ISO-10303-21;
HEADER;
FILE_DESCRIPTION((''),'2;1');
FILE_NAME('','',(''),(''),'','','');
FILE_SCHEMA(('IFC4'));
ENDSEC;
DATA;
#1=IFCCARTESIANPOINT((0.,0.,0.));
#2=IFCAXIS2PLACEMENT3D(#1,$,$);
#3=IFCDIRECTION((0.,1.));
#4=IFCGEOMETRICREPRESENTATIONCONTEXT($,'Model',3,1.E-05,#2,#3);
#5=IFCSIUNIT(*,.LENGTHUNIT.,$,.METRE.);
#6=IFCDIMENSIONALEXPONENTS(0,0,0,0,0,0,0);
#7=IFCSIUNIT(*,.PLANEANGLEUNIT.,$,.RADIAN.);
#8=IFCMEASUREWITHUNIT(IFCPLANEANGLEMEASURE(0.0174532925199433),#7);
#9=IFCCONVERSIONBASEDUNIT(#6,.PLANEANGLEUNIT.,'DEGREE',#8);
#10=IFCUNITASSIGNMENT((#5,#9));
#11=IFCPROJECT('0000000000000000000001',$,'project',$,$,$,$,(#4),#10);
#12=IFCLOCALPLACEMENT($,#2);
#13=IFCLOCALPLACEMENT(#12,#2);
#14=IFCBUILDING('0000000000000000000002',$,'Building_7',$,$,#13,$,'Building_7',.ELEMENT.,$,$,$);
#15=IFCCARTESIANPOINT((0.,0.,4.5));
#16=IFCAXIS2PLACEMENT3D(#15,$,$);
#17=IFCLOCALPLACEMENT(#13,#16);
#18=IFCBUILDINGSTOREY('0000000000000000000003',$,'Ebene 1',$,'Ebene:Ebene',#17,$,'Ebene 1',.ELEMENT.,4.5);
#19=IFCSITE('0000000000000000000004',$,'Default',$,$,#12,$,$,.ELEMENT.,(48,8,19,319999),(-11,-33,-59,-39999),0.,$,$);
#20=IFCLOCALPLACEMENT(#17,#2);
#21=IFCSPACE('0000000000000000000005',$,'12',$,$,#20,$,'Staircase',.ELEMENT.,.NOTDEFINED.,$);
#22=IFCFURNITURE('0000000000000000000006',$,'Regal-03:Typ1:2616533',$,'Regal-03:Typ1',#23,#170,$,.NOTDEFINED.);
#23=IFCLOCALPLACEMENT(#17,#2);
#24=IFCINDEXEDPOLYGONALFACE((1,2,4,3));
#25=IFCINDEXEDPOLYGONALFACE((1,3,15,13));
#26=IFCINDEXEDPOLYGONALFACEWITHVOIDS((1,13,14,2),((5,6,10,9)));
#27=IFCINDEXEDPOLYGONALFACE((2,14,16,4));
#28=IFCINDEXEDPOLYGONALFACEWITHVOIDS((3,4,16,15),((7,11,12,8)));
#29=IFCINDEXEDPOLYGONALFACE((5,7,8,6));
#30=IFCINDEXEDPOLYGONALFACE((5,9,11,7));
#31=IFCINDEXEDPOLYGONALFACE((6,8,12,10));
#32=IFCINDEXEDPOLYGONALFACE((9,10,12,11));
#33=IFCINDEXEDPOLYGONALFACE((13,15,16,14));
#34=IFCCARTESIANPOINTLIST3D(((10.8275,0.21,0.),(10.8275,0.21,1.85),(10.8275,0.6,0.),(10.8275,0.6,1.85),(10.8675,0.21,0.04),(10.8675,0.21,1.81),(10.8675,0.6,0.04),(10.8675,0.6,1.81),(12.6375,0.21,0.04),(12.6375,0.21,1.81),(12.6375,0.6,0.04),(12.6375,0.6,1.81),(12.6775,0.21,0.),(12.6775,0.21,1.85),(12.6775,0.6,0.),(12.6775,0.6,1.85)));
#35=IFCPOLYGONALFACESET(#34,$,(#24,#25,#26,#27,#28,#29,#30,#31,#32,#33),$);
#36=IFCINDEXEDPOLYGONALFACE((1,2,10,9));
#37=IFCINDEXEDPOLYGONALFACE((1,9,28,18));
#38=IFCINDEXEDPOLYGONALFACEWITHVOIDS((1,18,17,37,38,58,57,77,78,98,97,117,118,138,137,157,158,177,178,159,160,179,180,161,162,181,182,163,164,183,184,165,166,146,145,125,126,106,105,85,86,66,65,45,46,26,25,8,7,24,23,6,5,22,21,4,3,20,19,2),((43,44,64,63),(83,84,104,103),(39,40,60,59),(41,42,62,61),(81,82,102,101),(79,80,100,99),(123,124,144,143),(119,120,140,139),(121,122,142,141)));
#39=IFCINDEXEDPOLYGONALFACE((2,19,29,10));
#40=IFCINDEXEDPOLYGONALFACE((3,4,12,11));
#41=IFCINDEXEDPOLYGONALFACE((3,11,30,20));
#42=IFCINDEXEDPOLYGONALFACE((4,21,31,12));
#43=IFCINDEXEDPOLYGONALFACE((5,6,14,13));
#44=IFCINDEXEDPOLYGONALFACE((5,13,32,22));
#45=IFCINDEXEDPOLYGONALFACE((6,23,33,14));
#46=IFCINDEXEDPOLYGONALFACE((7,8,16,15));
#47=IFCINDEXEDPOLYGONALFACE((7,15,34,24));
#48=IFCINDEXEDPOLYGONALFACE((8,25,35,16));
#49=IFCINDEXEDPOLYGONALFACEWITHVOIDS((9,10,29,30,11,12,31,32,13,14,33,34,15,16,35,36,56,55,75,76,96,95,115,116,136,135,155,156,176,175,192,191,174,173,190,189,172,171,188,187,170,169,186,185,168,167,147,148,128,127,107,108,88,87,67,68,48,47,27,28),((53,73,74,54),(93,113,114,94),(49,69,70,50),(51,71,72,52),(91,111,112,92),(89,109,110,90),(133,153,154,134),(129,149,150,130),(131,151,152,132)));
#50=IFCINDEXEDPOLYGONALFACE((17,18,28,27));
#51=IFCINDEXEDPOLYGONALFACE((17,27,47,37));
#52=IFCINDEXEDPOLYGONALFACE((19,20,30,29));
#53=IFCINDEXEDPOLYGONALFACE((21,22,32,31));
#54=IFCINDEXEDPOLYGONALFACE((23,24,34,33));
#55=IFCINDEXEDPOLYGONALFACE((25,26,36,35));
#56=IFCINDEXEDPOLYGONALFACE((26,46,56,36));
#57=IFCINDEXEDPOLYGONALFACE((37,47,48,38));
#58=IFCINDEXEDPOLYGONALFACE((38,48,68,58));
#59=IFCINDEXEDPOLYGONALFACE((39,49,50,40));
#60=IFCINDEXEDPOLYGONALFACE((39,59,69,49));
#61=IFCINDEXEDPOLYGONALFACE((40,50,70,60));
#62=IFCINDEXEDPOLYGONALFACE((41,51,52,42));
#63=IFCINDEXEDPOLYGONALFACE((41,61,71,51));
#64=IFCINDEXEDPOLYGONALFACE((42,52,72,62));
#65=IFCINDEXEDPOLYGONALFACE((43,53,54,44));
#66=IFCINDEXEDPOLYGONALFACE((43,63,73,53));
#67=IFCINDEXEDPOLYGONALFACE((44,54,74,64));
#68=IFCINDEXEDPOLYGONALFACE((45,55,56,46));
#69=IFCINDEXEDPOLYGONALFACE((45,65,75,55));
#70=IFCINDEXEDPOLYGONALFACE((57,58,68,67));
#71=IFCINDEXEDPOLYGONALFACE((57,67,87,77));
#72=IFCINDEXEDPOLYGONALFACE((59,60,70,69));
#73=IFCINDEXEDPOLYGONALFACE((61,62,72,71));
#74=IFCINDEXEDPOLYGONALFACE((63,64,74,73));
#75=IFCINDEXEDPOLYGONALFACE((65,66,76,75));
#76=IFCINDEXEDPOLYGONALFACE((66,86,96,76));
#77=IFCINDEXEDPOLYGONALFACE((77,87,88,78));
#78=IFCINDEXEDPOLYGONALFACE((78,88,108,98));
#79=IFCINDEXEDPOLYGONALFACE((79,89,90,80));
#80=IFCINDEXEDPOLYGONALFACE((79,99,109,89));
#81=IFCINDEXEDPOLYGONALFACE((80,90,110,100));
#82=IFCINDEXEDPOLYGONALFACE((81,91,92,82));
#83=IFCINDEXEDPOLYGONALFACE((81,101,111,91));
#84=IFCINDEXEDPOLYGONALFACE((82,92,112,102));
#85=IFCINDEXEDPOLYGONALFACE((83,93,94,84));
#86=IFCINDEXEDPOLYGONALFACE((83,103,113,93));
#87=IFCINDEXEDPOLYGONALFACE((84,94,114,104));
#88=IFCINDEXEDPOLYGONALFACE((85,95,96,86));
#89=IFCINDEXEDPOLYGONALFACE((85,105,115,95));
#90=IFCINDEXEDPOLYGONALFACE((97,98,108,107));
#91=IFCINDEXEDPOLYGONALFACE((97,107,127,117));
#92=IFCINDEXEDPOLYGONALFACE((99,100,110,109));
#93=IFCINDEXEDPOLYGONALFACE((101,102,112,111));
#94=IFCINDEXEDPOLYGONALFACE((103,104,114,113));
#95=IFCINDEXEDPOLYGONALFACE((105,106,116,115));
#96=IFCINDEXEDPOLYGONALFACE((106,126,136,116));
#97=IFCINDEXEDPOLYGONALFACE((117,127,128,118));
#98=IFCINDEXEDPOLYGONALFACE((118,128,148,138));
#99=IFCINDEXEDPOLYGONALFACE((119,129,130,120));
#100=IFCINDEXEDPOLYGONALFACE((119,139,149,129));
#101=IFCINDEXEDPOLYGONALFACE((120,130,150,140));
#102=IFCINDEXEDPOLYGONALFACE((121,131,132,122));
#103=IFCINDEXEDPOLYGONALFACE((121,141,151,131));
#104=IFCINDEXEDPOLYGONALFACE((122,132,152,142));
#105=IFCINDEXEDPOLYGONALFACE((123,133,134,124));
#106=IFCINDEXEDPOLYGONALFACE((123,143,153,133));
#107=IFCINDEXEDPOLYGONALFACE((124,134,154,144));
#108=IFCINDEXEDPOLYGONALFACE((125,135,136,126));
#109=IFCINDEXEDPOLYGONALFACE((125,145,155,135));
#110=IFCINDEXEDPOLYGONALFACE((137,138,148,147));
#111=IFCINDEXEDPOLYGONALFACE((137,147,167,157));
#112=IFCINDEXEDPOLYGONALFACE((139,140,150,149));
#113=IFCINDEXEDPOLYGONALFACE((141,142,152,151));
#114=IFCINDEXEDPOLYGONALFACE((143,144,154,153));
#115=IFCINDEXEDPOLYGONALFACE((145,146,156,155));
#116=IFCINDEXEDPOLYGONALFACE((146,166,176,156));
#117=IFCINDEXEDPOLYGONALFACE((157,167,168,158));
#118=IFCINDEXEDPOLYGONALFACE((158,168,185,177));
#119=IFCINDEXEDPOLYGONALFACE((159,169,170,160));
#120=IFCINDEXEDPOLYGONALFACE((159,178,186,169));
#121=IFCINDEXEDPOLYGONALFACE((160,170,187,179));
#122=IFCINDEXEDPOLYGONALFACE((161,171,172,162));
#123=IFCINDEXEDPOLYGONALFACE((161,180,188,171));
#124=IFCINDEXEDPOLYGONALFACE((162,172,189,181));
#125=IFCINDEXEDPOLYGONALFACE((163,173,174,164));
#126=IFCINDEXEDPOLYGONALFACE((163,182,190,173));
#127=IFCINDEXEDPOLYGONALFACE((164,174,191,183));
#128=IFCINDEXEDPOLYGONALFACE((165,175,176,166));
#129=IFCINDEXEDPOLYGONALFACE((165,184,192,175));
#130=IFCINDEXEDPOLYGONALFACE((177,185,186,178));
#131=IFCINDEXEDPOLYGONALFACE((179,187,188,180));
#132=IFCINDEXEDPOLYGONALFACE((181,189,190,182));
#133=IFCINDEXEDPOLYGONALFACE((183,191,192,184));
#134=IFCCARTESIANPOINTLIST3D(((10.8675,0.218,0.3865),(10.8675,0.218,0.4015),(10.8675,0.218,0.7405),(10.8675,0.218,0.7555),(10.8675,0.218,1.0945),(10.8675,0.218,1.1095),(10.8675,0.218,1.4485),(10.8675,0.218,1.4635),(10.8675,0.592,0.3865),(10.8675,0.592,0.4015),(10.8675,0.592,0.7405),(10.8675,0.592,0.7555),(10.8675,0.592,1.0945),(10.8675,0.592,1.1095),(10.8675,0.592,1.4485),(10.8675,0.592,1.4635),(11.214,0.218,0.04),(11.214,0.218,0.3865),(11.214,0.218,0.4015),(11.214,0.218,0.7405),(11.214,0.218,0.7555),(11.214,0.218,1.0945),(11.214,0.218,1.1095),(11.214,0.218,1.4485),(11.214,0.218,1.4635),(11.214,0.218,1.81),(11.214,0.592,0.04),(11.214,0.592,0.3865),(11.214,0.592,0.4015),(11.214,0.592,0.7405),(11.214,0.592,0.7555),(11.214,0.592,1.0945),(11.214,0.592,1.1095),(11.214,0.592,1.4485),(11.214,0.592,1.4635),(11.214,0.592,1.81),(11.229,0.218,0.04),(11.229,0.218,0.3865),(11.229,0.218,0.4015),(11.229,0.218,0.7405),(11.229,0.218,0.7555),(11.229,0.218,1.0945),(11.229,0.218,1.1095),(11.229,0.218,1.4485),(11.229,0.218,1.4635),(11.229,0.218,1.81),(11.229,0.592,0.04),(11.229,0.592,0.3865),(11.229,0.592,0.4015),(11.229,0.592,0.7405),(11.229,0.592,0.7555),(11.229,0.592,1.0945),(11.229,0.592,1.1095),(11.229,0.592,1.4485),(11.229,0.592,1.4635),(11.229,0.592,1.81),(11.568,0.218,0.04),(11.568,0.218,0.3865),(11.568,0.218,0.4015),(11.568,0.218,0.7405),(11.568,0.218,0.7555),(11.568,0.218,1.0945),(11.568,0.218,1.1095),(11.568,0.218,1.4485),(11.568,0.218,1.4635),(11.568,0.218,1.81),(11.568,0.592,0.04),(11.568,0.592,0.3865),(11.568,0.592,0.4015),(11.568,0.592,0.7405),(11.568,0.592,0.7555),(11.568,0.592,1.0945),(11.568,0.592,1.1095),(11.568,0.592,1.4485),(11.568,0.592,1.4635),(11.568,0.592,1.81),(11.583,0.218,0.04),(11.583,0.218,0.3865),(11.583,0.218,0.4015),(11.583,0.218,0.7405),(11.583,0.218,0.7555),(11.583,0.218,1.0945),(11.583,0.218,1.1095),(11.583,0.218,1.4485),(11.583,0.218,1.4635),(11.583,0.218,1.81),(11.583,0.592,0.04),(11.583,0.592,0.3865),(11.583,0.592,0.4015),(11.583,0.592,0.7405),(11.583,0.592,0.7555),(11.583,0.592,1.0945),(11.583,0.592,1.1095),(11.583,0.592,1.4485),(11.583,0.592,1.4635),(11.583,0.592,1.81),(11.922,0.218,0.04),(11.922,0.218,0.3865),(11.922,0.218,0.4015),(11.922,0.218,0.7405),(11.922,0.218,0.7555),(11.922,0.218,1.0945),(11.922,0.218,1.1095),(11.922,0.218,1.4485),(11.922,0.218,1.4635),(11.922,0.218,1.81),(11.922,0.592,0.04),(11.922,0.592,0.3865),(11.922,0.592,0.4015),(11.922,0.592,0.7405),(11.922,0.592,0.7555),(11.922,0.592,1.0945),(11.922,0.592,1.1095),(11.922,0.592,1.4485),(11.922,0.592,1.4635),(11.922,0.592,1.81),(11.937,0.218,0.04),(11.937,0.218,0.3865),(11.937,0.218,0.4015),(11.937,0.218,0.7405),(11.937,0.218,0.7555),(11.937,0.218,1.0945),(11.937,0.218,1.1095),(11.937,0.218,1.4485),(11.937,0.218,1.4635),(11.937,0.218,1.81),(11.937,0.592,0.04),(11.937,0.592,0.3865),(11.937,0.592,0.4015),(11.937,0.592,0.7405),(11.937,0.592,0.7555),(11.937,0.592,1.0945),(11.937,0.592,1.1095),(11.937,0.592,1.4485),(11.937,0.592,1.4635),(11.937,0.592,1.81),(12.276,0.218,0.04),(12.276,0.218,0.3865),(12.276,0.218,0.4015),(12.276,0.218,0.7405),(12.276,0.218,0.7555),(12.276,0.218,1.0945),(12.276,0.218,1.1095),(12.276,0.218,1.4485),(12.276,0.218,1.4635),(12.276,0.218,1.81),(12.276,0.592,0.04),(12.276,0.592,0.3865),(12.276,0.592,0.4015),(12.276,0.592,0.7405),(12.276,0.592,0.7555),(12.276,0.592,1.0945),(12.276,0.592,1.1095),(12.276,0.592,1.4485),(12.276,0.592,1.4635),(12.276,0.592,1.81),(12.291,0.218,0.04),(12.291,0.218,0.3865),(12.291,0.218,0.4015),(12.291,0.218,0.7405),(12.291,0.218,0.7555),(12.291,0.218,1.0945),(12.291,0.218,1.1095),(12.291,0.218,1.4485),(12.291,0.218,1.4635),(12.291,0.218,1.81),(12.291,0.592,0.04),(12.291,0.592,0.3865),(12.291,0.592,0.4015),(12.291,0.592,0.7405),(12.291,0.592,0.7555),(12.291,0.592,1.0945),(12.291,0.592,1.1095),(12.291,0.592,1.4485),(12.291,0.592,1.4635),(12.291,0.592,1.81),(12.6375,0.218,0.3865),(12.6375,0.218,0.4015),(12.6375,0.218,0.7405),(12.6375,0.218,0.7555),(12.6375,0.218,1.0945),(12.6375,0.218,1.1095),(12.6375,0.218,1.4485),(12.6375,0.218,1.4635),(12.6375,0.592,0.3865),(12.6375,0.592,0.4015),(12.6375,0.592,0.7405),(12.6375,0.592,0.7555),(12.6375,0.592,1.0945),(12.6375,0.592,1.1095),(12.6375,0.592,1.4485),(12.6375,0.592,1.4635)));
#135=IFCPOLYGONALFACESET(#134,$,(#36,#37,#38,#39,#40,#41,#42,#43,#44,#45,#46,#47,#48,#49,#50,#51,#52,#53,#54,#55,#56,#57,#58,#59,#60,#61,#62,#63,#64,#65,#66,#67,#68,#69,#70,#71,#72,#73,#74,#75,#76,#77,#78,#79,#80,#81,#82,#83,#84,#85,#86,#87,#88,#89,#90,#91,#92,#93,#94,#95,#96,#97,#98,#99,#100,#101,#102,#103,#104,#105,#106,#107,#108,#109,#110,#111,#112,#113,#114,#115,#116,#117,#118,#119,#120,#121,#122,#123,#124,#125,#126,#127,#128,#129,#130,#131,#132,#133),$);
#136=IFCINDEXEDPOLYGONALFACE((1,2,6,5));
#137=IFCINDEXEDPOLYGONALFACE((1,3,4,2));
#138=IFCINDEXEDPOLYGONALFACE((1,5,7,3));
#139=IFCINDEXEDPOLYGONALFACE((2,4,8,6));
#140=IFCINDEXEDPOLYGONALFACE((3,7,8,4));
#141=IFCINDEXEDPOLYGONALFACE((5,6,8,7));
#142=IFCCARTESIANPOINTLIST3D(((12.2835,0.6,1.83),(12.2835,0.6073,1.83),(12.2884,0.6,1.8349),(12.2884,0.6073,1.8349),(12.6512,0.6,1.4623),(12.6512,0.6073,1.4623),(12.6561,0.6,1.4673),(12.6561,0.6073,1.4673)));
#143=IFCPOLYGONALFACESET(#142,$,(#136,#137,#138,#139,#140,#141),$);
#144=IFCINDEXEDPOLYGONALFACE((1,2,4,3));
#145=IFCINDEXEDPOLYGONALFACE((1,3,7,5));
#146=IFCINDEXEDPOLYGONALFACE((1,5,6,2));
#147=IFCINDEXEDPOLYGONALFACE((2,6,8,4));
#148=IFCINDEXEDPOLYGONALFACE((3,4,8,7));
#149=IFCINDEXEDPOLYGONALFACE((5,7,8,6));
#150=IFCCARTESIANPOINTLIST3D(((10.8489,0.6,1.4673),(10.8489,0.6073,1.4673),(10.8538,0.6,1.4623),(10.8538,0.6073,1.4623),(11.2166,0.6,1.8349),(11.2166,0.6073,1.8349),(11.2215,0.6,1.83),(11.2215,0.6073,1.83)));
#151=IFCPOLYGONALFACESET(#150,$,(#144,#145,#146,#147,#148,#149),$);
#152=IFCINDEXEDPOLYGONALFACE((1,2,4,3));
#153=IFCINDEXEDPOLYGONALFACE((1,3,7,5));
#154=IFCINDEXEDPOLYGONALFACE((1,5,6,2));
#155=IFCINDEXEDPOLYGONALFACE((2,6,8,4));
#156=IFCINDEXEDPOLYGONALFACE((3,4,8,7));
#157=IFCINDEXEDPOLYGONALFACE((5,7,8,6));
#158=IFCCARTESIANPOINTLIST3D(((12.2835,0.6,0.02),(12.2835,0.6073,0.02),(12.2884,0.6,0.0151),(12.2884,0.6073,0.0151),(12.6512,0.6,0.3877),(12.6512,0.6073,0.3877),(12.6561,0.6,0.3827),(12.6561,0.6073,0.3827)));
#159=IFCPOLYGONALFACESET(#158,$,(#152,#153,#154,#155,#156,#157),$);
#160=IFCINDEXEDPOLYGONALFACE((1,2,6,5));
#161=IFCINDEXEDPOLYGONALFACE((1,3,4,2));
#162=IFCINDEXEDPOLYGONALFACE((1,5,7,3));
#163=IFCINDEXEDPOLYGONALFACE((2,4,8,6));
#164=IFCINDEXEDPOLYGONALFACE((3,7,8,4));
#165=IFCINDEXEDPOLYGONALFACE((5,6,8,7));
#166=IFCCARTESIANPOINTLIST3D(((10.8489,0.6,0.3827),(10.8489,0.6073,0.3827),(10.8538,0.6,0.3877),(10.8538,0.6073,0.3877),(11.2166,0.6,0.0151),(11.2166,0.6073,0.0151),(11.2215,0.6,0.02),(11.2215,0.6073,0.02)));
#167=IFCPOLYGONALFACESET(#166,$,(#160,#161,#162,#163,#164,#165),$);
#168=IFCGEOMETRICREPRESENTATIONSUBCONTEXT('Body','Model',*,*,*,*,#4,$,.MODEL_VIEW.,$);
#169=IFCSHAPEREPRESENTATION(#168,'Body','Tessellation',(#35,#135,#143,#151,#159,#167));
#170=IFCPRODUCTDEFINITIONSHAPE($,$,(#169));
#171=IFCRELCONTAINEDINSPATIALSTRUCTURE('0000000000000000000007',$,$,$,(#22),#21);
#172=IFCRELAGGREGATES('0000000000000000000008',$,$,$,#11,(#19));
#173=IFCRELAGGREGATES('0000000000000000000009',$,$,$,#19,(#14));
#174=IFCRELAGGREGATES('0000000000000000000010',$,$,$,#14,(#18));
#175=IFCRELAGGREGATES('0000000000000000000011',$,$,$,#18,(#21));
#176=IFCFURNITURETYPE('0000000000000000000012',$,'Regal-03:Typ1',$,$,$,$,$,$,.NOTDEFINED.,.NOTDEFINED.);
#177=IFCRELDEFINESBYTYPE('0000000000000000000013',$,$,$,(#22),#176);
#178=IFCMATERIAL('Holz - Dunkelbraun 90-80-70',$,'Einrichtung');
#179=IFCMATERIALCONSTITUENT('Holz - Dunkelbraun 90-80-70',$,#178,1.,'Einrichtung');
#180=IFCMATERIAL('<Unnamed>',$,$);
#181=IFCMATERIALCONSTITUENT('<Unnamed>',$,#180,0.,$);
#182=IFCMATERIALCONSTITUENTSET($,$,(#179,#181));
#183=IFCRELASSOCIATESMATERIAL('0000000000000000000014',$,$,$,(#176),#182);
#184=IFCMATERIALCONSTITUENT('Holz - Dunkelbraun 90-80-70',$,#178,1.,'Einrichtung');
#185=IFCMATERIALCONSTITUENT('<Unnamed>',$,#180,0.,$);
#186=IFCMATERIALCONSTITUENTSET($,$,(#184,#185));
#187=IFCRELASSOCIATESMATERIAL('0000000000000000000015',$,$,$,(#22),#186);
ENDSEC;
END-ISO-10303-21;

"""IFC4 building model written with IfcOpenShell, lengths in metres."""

from ifc_helpers import new_model, entity, si_unit, converted_unit, direction, frame, origin, place, context, subcontext, project, spatial, indexed_curve, outline, extrude, source, transform, mapped, material, constituent, constituent_set, type_object, type_shapes, element, save


model = new_model("IFC4")

# Units and contexts
model_context = context("Model", 3, precision=1e-05, world=origin(), true_north=direction((0.0, 1.0)))
body_context = subcontext(model_context, "Body", "Model", "MODEL_VIEW")
ifc_project = project(units=[si_unit("LENGTHUNIT", "METRE"), converted_unit("PLANEANGLEUNIT", "DEGREE", entity("IfcPlaneAngleMeasure", 0.0174532925199433), si_unit("PLANEANGLEUNIT", "RADIAN"), dimensions=[0, 0, 0, 0, 0, 0, 0])], contexts=[model_context])

# Site, building, storey
site_placement = place(None, origin())
site = spatial("IfcSite", under=ifc_project, at=site_placement, Name="Default", CompositionType="ELEMENT", RefLatitude=(48, 8, 19, 319999), RefLongitude=(-11, -33, -59, -39999), RefElevation=0.0)
building_placement = place(site_placement, origin())
building = spatial("IfcBuilding", under=site, at=building_placement, Name="Building_7", LongName="Building_7", CompositionType="ELEMENT")
storey_placement = place(building_placement, frame((0.0, 0.0, 4.5)))
storey = spatial("IfcBuildingStorey", under=building, at=storey_placement, Name="Ebene 1", ObjectType="Ebene:Ebene", LongName="Ebene 1", CompositionType="ELEMENT", Elevation=4.5)

# Shared definitions
ifc_material_1 = material(Name="<Unnamed>")

# Shared definitions
ifc_material_2 = material(Name="Holz - Dunkelbraun 90-80-70", Category="Einrichtung")
ifc_constituent_1 = constituent(ifc_material_2, Name="Holz - Dunkelbraun 90-80-70", Category="Einrichtung", fraction=1.0)
ifc_constituent_2 = constituent(ifc_material_1, Name="<Unnamed>", fraction=0.0)
ifc_constituent_set_1 = constituent_set(constituents=[ifc_constituent_1, ifc_constituent_2])
furniture_type_1 = type_object("IfcFurnitureType", Name="Regal-03:Typ1", AssemblyPlace="NOTDEFINED", PredefinedType="NOTDEFINED", material=ifc_constituent_set_1)
shared_shape_1 = source(origin(), body_context, "Body", "SweptSolid", [
    extrude(outline(indexed_curve([(-0.925, -0.925), (0.925, -0.925), (0.925, 0.925), (-0.925, 0.925), (-0.925, -0.925)], self_intersect=False), holes=[indexed_curve([(-0.885, -0.885), (-0.885, 0.885), (0.885, 0.885), (0.885, -0.885), (-0.885, -0.885)], self_intersect=False)]), frame((0.2471, -0.2651, 0.925), z_axis=(0.0, 1.0, 0.0), x_axis=(0.0, 0.0, -1.0)), (0.0, 0.0, 1.0), 0.39),
    extrude(outline(indexed_curve([(0.5385, -0.5385), (0.885, -0.5385), (0.885, -0.5235), (0.5385, -0.5235), (0.5385, -0.1845), (0.885, -0.1845), (0.885, -0.1695), (0.5385, -0.1695), (0.5385, 0.1695), (0.885, 0.1695), (0.885, 0.1845), (0.5385, 0.1845), (0.5385, 0.5235), (0.885, 0.5235), (0.885, 0.5385), (0.5385, 0.5385), (0.5385, 0.885), (0.5235, 0.885), (0.5235, 0.5385), (0.1845, 0.5385), (0.1845, 0.885), (0.1695, 0.885), (0.1695, 0.5385), (-0.1695, 0.5385), (-0.1695, 0.885), (-0.1845, 0.885), (-0.1845, 0.5385), (-0.5235, 0.5385), (-0.5235, 0.885), (-0.5385, 0.885), (-0.5385, 0.5385), (-0.885, 0.5385), (-0.885, 0.5235), (-0.5385, 0.5235), (-0.5385, 0.1845), (-0.885, 0.1845), (-0.885, 0.1695), (-0.5385, 0.1695), (-0.5385, -0.1695), (-0.885, -0.1695), (-0.885, -0.1845), (-0.5385, -0.1845), (-0.5385, -0.5235), (-0.885, -0.5235), (-0.885, -0.5385), (-0.5385, -0.5385), (-0.5385, -0.885), (-0.5235, -0.885), (-0.5235, -0.5385), (-0.1845, -0.5385), (-0.1845, -0.885), (-0.1695, -0.885), (-0.1695, -0.5385), (0.1695, -0.5385), (0.1695, -0.885), (0.1845, -0.885), (0.1845, -0.5385), (0.5235, -0.5385), (0.5235, -0.885), (0.5385, -0.885), (0.5385, -0.5385)], self_intersect=False), holes=[indexed_curve([(0.5235, -0.1845), (0.5235, -0.5235), (0.1845, -0.5235), (0.1845, -0.1845), (0.5235, -0.1845)], self_intersect=False), indexed_curve([(0.1845, -0.1695), (0.1845, 0.1695), (0.5235, 0.1695), (0.5235, -0.1695), (0.1845, -0.1695)], self_intersect=False), indexed_curve([(0.1845, 0.1845), (0.1845, 0.5235), (0.5235, 0.5235), (0.5235, 0.1845), (0.1845, 0.1845)], self_intersect=False), indexed_curve([(-0.1695, 0.5235), (0.1695, 0.5235), (0.1695, 0.1845), (-0.1695, 0.1845), (-0.1695, 0.5235)], self_intersect=False), indexed_curve([(-0.1695, 0.1695), (0.1695, 0.1695), (0.1695, -0.1695), (-0.1695, -0.1695), (-0.1695, 0.1695)], self_intersect=False), indexed_curve([(-0.1695, -0.1845), (0.1695, -0.1845), (0.1695, -0.5235), (-0.1695, -0.5235), (-0.1695, -0.1845)], self_intersect=False), indexed_curve([(-0.5235, -0.5235), (-0.5235, -0.1845), (-0.1845, -0.1845), (-0.1845, -0.5235), (-0.5235, -0.5235)], self_intersect=False), indexed_curve([(-0.5235, -0.1695), (-0.5235, 0.1695), (-0.1845, 0.1695), (-0.1845, -0.1695), (-0.5235, -0.1695)], self_intersect=False), indexed_curve([(-0.5235, 0.1845), (-0.5235, 0.5235), (-0.1845, 0.5235), (-0.1845, 0.1845), (-0.5235, 0.1845)], self_intersect=False)]), frame((0.2471, -0.2571, 0.925), z_axis=(0.0, 1.0, 0.0), x_axis=(0.0, 0.0, 1.0)), (0.0, 0.0, 1.0), 0.374),
    extrude(outline(indexed_curve([(-0.0037, -0.0035), (0.0037, -0.0035), (0.0037, 0.0035), (-0.0037, 0.0035), (-0.0037, -0.0035)], self_intersect=False)), frame((1.1482, 0.1286, 1.4648), z_axis=(-0.707107, 0.0, 0.707107), x_axis=(0.0, 1.0, 0.0)), (0.0, 0.0, 1.0), 0.52),
    extrude(outline(indexed_curve([(-0.0037, -0.0035), (0.0037, -0.0035), (0.0037, 0.0035), (-0.0037, 0.0035), (-0.0037, -0.0035)], self_intersect=False)), frame((-0.6541, 0.1286, 1.4648), z_axis=(0.707107, 0.0, 0.707107), x_axis=(0.0, 1.0, 0.0)), (0.0, 0.0, 1.0), 0.52),
    extrude(outline(indexed_curve([(-0.0037, -0.0035), (0.0037, -0.0035), (0.0037, 0.0035), (-0.0037, 0.0035), (-0.0037, -0.0035)], self_intersect=False)), frame((0.7805, 0.1286, 0.0175), z_axis=(0.707107, 0.0, 0.707107), x_axis=(0.0, 1.0, 0.0)), (0.0, 0.0, 1.0), 0.52),
    extrude(outline(indexed_curve([(-0.0037, -0.0035), (0.0037, -0.0035), (0.0037, 0.0035), (-0.0037, 0.0035), (-0.0037, -0.0035)], self_intersect=False)), frame((-0.2864, 0.1286, 0.0175), z_axis=(-0.707107, 0.0, 0.707107), x_axis=(0.0, 1.0, 0.0)), (0.0, 0.0, 1.0), 0.52),
])
type_shapes(furniture_type_1, [shared_shape_1])

# Shared definitions
space_1_placement = place(storey_placement, origin())
space_1 = spatial("IfcSpace", under=storey, at=space_1_placement, Name="12", LongName="Staircase", CompositionType="ELEMENT", PredefinedType="NOTDEFINED")

# Furniture
ifc_constituent_3 = constituent(ifc_material_2, Name="Holz - Dunkelbraun 90-80-70", Category="Einrichtung", fraction=1.0)
ifc_constituent_4 = constituent(ifc_material_1, Name="<Unnamed>", fraction=0.0)
ifc_constituent_set_2 = constituent_set(constituents=[ifc_constituent_3, ifc_constituent_4])
furniture_1_placement = place(space_1_placement, frame((11.5054, 0.4751, 0.0)))
element("IfcFurniture", 1, at=furniture_1_placement, inside=space_1, type_object=furniture_type_1, material=ifc_constituent_set_2, Name="Regal-03:Typ1:2616533", ObjectType="Regal-03:Typ1", PredefinedType="NOTDEFINED", context=body_context, shape_type="MappedRepresentation", body=[
    mapped(shared_shape_1, transform((0.0, 0.0, 0.0), scale=1.0)),
])

save(model, "model.ifc")
